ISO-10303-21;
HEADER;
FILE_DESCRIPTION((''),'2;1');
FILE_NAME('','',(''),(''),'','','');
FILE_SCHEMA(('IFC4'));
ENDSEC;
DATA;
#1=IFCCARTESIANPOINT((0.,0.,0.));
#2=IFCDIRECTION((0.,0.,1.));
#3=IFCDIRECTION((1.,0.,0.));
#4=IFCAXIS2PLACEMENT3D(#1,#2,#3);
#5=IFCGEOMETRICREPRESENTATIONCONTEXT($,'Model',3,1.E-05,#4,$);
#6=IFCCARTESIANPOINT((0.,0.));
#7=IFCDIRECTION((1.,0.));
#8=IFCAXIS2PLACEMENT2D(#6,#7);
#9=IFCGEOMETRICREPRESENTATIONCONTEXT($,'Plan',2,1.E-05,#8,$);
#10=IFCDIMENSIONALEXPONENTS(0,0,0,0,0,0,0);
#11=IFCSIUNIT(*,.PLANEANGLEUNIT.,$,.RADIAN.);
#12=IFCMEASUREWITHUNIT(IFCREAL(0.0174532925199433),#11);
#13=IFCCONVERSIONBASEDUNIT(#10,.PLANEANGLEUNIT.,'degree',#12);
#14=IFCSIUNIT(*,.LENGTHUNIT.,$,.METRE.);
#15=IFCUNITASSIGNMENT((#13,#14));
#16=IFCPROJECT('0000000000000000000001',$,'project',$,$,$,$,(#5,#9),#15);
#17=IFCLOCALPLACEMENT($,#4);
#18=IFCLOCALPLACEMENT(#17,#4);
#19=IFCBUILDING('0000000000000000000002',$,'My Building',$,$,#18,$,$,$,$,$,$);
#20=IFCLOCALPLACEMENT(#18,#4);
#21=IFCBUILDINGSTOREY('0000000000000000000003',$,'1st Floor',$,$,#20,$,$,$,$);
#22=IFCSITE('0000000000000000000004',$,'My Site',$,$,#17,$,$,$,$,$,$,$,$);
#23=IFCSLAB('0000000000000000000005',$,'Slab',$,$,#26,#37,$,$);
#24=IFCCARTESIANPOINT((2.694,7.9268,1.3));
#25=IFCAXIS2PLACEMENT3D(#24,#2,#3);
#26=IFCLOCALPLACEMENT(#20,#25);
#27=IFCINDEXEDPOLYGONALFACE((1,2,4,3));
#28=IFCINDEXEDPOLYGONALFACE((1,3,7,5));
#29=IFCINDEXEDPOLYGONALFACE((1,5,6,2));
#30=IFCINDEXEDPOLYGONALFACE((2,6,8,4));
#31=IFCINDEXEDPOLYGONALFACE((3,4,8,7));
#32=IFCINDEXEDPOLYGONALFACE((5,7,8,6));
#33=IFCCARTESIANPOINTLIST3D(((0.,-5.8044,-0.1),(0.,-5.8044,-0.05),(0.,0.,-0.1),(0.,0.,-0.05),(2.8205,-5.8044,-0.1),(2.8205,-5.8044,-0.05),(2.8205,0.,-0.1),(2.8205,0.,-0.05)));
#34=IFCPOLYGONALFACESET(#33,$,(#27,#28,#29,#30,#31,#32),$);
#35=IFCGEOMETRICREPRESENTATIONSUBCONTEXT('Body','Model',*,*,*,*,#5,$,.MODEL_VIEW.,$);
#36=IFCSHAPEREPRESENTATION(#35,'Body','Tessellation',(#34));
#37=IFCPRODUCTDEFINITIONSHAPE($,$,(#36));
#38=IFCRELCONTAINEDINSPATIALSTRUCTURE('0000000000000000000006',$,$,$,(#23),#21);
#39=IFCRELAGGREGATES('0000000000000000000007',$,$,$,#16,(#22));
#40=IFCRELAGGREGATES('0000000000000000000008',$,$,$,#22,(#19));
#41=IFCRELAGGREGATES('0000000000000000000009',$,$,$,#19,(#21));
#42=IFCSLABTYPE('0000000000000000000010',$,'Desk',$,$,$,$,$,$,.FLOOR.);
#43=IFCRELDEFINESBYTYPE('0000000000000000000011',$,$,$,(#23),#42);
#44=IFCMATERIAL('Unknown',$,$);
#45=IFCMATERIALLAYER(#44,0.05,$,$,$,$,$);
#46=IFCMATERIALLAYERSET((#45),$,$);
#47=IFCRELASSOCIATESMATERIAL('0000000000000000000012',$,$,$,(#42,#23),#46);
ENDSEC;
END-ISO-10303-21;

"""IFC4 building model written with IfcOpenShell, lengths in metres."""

from ifc_helpers import new_model, entity, si_unit, converted_unit, frame, origin_with_axes, origin_2d_with_axis, place, context, subcontext, project, spatial, indexed_curve, outline, extrude, material, layer, layer_set, layer_usage, type_object, element, save


model = new_model("IFC4")

# Units and contexts
model_context = context("Model", 3, precision=1e-05, world=origin_with_axes())
plan_context = context("Plan", 2, precision=1e-05, world=origin_2d_with_axis())
body_context_1 = subcontext(model_context, "Body", "Model", "MODEL_VIEW")
ifc_project = project(units=[converted_unit("PLANEANGLEUNIT", "degree", entity("IfcReal", 0.0174532925199433), si_unit("PLANEANGLEUNIT", "RADIAN"), dimensions=[0, 0, 0, 0, 0, 0, 0]), si_unit("LENGTHUNIT", "METRE")], contexts=[model_context, plan_context])

# Site, building, storey
site_placement = place(None, origin_with_axes())
site = spatial("IfcSite", under=ifc_project, at=site_placement, Name="My Site")
building_placement = place(site_placement, origin_with_axes())
building = spatial("IfcBuilding", under=site, at=building_placement, Name="My Building")
storey_placement = place(building_placement, origin_with_axes())
storey = spatial("IfcBuildingStorey", under=building, at=storey_placement, Name="1st Floor")

# Shared definitions
ifc_material = material(Name="Unknown")

# Slab
ifc_layer_1 = layer(ifc_material, 0.05)
ifc_layer_set_1 = layer_set([ifc_layer_1])
ifc_layer_usage_1 = layer_usage(ifc_layer_set_1, "AXIS3", "POSITIVE", -0.1)
slab_type = type_object("IfcSlabType", Name="Desk", PredefinedType="FLOOR", material=ifc_layer_set_1)
slab_placement = place(storey_placement, frame((2.694, 7.9268, 1.3), z_axis=(0.0, 0.0, 1.0), x_axis=(1.0, 0.0, 0.0)))
element("IfcSlab", 1, at=slab_placement, inside=storey, type_object=slab_type, material=ifc_layer_usage_1, Name="Slab", context=body_context_1, shape_type="SweptSolid", body=[
    extrude(outline(indexed_curve([(0.0, 0.0), (2.8205, 0.0), (2.8205, -5.8044), (0.0, -5.8044), (0.0, 0.0)])), frame((0.0, 0.0, -0.1), z_axis=(0.0, 0.0, 1.0), x_axis=(1.0, 0.0, 0.0)), (0.0, 0.0, 1.0), 0.05),
])

save(model, "model.ifc")
